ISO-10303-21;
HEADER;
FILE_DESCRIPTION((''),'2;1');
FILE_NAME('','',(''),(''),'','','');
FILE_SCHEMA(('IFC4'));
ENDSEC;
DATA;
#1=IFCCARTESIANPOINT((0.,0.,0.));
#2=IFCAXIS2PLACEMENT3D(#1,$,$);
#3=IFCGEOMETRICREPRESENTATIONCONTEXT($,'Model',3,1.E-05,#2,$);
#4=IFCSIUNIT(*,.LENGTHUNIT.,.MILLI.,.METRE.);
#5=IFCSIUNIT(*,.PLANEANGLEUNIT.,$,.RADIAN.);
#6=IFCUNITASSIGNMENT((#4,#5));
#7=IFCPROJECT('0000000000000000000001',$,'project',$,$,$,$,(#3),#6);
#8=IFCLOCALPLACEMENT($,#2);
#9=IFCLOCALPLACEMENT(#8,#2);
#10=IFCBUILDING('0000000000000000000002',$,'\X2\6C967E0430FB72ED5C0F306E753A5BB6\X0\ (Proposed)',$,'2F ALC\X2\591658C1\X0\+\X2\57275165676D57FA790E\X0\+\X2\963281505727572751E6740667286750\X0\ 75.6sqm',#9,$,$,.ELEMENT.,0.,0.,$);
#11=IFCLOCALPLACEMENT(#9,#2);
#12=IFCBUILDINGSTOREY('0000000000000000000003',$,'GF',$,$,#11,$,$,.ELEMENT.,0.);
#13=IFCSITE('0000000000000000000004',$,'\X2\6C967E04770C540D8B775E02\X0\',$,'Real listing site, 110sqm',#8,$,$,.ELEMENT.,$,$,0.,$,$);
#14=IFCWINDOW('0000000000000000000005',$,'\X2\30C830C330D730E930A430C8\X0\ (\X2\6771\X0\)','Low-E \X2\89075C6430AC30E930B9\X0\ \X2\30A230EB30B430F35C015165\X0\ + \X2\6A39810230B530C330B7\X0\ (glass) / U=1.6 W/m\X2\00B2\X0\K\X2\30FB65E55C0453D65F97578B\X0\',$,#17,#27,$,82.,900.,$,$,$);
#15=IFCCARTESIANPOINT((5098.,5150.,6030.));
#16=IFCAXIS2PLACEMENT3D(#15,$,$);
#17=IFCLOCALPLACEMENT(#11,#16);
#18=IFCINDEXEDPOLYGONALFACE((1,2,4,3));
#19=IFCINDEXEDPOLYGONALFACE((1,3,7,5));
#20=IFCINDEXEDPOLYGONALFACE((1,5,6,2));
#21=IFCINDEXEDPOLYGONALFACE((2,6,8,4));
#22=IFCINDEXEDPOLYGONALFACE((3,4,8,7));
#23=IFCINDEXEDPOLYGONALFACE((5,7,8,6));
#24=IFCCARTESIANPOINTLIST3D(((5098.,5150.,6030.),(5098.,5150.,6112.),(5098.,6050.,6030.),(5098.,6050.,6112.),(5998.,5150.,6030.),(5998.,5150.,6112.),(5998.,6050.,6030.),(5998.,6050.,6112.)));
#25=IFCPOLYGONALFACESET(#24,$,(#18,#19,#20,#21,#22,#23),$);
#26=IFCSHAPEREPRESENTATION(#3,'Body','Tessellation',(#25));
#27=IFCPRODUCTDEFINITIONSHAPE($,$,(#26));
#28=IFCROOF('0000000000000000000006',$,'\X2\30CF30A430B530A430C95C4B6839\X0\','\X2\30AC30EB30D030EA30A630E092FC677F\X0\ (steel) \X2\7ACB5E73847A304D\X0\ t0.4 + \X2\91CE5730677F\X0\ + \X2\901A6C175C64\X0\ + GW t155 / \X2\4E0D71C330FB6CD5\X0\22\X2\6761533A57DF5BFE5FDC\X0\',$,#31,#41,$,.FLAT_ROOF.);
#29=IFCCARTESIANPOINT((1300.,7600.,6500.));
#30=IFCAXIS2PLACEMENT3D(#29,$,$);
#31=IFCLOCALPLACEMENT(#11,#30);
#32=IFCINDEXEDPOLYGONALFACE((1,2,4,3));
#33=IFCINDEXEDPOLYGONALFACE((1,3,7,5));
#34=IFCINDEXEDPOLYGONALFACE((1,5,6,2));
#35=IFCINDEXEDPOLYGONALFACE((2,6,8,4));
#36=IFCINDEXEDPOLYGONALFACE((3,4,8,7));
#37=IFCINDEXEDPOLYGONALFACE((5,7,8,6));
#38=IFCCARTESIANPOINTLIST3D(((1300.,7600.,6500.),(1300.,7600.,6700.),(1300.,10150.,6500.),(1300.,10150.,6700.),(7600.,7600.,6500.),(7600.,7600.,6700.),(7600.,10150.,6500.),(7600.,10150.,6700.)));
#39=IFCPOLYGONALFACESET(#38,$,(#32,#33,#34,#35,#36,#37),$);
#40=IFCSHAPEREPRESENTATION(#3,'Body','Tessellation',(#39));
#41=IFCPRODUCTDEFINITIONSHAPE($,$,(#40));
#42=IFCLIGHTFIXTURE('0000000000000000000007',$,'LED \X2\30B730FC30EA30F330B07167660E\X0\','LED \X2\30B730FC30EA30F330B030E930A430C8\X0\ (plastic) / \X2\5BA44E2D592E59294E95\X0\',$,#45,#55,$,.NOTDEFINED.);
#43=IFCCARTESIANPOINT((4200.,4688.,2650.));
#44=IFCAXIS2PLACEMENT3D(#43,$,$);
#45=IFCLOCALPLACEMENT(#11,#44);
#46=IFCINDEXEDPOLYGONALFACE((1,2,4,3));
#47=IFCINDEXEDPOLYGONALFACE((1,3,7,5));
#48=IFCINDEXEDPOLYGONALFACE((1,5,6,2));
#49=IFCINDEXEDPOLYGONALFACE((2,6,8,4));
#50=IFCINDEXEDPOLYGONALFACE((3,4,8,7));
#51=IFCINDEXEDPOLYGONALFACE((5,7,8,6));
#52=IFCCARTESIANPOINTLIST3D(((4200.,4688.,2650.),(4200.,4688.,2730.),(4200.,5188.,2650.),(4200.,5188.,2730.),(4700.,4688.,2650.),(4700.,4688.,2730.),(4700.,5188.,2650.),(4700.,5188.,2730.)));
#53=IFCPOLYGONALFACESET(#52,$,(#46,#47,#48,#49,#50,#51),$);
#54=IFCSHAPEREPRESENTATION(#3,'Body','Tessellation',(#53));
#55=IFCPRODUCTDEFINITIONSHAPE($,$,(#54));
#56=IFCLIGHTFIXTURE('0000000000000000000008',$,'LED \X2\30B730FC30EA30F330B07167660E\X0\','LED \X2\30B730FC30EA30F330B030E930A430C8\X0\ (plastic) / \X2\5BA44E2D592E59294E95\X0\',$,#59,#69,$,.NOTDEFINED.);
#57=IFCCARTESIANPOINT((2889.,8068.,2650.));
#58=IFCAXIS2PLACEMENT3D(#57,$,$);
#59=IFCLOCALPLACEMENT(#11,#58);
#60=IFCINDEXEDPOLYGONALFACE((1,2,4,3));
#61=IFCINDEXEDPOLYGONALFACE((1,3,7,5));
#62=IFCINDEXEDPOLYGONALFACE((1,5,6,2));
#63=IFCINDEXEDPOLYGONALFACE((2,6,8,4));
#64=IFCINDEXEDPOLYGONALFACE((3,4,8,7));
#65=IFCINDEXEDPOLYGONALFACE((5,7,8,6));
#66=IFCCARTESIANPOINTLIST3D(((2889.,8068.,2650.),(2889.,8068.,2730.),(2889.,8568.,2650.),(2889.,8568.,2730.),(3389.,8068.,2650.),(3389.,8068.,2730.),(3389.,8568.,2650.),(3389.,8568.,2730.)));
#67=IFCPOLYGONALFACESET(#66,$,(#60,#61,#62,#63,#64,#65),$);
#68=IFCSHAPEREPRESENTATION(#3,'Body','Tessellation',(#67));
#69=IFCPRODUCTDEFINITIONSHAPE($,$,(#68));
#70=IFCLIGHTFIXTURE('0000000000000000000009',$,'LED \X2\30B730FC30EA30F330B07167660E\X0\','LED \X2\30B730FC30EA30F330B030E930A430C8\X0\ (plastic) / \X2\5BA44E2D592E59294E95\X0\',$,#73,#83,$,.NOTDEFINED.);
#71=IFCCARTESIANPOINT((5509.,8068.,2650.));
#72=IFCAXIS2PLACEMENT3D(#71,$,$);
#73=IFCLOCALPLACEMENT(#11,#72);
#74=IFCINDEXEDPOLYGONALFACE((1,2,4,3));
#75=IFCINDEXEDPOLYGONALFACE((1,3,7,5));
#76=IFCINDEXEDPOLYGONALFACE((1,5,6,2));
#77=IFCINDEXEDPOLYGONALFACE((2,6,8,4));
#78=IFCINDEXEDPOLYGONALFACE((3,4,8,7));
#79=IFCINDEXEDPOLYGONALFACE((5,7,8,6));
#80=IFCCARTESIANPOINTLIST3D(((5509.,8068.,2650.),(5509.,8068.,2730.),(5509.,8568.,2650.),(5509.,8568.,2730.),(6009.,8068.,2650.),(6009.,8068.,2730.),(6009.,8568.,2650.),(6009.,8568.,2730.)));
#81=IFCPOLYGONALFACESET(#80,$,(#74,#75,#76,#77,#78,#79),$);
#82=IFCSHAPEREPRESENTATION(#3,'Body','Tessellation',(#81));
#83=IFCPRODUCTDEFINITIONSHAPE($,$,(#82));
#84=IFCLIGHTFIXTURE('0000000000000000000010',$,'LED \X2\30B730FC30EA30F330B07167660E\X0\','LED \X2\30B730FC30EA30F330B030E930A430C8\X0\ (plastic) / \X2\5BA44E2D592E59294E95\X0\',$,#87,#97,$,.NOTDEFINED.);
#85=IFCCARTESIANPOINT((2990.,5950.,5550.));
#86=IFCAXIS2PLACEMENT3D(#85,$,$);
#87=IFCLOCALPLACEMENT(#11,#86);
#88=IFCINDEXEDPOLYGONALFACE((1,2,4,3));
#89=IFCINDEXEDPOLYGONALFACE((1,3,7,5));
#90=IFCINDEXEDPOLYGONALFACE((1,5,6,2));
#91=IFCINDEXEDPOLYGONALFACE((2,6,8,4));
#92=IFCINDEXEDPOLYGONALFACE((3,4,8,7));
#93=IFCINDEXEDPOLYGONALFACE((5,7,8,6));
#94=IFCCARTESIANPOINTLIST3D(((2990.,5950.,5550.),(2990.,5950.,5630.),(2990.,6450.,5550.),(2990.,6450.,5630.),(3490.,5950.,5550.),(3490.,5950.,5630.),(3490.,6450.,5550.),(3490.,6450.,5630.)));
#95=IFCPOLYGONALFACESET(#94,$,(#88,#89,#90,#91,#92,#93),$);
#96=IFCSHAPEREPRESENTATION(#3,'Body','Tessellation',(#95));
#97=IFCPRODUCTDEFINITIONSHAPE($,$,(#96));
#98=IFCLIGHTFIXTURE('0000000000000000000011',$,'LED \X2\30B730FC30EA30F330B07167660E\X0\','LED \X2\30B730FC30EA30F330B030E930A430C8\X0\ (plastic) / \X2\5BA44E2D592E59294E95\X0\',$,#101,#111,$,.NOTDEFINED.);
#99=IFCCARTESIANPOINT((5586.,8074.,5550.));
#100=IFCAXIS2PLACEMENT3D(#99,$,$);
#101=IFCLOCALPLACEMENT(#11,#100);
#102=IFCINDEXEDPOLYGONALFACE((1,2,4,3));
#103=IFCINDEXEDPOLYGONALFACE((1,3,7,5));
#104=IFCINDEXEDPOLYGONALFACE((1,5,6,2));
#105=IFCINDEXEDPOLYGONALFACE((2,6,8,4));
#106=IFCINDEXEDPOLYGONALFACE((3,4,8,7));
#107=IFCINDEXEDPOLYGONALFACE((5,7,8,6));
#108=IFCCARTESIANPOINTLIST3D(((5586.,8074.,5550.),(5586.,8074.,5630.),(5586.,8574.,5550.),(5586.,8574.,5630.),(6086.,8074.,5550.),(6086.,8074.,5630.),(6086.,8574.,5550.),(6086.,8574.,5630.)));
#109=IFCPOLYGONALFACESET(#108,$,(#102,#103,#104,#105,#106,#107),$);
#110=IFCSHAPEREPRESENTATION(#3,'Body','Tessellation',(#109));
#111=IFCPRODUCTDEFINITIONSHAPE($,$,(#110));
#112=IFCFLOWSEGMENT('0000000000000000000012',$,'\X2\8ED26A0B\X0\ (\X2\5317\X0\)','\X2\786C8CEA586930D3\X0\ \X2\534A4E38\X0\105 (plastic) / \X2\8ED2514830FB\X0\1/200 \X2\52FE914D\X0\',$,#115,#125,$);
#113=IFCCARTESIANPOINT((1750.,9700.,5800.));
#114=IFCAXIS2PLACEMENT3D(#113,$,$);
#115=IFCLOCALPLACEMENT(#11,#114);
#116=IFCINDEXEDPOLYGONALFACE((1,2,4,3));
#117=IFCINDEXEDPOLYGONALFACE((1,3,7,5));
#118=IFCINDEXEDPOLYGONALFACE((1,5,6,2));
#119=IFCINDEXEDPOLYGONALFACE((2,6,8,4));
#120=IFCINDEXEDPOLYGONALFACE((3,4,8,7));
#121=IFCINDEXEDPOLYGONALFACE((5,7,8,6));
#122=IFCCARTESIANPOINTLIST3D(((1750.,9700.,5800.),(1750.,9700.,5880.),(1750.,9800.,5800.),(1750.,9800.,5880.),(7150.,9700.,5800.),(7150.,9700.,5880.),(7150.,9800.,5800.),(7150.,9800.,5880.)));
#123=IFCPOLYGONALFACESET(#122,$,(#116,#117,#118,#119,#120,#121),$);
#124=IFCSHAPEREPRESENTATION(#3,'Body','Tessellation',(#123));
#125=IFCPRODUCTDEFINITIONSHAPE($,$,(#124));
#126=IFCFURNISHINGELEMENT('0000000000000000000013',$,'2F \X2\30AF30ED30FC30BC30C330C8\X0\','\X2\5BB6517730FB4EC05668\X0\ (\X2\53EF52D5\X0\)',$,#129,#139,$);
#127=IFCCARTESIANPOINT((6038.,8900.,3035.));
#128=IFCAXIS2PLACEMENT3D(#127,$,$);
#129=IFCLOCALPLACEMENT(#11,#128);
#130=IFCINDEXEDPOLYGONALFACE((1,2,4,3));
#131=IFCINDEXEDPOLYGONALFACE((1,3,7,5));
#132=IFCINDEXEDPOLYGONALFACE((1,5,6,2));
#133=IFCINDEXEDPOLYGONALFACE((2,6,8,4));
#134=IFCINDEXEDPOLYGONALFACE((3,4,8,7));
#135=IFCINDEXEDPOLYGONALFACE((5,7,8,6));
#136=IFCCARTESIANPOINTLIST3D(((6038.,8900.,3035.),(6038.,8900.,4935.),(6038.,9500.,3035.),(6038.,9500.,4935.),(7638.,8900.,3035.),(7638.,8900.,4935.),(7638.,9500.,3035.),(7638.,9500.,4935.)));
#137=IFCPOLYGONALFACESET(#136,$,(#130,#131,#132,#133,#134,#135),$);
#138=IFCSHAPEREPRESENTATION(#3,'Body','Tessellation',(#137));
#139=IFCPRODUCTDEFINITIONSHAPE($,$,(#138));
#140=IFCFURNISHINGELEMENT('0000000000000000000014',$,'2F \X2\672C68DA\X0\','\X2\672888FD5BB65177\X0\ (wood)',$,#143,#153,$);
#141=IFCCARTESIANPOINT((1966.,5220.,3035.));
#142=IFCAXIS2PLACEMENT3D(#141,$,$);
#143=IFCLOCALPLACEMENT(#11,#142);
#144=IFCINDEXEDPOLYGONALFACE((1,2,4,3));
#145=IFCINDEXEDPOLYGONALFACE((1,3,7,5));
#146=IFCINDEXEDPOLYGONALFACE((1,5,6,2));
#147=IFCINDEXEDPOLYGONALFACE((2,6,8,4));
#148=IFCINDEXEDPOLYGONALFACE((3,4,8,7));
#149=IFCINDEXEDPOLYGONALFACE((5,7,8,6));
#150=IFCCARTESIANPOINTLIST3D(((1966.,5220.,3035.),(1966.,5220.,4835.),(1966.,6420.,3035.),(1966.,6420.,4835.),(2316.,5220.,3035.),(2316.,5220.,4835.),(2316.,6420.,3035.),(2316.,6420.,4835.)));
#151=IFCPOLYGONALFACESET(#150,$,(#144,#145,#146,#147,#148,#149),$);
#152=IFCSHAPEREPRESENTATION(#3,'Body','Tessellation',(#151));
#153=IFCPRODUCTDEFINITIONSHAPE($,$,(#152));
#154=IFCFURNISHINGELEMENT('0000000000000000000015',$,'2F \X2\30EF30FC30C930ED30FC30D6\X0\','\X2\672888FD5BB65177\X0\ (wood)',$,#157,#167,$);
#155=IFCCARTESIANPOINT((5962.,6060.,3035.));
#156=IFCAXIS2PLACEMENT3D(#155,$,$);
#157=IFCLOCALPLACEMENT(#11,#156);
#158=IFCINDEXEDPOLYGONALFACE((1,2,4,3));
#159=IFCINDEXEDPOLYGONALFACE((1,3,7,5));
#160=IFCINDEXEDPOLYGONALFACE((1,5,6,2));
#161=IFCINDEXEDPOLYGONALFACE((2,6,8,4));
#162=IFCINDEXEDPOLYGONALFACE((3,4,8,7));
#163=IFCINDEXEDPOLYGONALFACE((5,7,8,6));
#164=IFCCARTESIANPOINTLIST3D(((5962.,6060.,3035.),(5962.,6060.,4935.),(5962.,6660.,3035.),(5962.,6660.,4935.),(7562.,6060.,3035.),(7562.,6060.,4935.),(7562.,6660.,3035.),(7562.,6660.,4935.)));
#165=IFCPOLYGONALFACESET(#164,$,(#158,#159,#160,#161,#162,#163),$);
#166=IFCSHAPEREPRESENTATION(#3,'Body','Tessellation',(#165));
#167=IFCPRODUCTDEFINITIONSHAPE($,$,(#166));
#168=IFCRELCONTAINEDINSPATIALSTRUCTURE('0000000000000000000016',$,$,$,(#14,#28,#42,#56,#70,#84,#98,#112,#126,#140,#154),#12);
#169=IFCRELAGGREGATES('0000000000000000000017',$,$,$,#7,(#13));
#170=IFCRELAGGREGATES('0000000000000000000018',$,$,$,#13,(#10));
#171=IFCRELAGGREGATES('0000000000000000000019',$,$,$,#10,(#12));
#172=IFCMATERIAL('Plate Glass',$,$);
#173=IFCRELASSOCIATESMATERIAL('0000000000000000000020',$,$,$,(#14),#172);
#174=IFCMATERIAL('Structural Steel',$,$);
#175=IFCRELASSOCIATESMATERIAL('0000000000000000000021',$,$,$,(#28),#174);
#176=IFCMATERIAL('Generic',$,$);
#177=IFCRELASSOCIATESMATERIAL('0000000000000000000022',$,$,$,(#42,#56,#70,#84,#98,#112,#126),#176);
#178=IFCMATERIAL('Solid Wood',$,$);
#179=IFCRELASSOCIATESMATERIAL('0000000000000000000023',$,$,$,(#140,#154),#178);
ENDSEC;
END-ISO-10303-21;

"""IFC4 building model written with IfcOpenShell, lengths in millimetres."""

from ifc_helpers import new_model, si_unit, frame, frame_2d, origin, place, context, project, spatial, rectangle, extrude, material, element, save


model = new_model("IFC4")

# Units and contexts
model_context = context("Model", 3, precision=1e-05, world=origin())
ifc_project = project(units=[si_unit("LENGTHUNIT", "METRE", prefix="MILLI"), si_unit("PLANEANGLEUNIT", "RADIAN")], contexts=[model_context])

# Site, building, storey
site_placement = place(None, origin())
site = spatial("IfcSite", under=ifc_project, at=site_placement, Name="沖縄県名護市", ObjectType="Real listing site, 110sqm", CompositionType="ELEMENT", RefElevation=0.0)
building_placement = place(site_placement, origin())
building = spatial("IfcBuilding", under=site, at=building_placement, Name="沖縄・狭小の町家 (Proposed)", ObjectType="2F ALC外壁+圧入杭基礎+防腐圧圧処理木材 75.6sqm", CompositionType="ELEMENT", ElevationOfRefHeight=0.0, ElevationOfTerrain=0.0)
storey_placement = place(building_placement, origin())
storey = spatial("IfcBuildingStorey", under=building, at=storey_placement, Name="GF", CompositionType="ELEMENT", Elevation=0.0)

# Shared definitions
ifc_material_1 = material(Name="Solid Wood")

# Shared definitions
ifc_material_2 = material(Name="Plate Glass")

# Window
window_1_placement = place(storey_placement, frame((5098.0, 5150.0, 6030.0)))
element("IfcWindow", 1, at=window_1_placement, inside=storey, material=ifc_material_2, Name="トップライト (東)", Description="Low-E 複層ガラス アルゴン封入 + 樹脂サッシ (glass) / U=1.6 W/m²K・日射取得型", OverallHeight=82.0, OverallWidth=900.0, context=model_context, shape_type="SweptSolid", body=[
    extrude(rectangle(XDim=900.0, YDim=900.0, at=frame_2d((450.0, 450.0))), frame((5098.0, 5150.0, 6030.0)), (0.0, 0.0, 1.0), 82.0),
])

# Roof
ifc_material_3 = material(Name="Structural Steel")
roof_placement = place(storey_placement, frame((1300.0, 7600.0, 6500.0)))
element("IfcRoof", 2, at=roof_placement, inside=storey, material=ifc_material_3, Name="ハイサイド屋根", Description="ガルバリウム鋼板 (steel) 立平葺き t0.4 + 野地板 + 通気層 + GW t155 / 不燃・法22条区域対応", PredefinedType="FLAT_ROOF", context=model_context, shape_type="SweptSolid", body=[
    extrude(rectangle(XDim=6300.0, YDim=2550.0, at=frame_2d((3150.0, 1275.0))), frame((1300.0, 7600.0, 6500.0)), (0.0, 0.0, 1.0), 200.0),
])

# Light fixtures
ifc_material_4 = material(Name="Generic")
light_fixture_1_placement = place(storey_placement, frame((4200.0, 4688.0, 2650.0)))
element("IfcLightFixture", 3, at=light_fixture_1_placement, inside=storey, material=ifc_material_4, Name="LED シーリング照明", Description="LED シーリングライト (plastic) / 室中央天井", PredefinedType="NOTDEFINED", context=model_context, shape_type="SweptSolid", body=[
    extrude(rectangle(XDim=500.0, YDim=500.0, at=frame_2d((250.0, 250.0))), frame((4200.0, 4688.0, 2650.0)), (0.0, 0.0, 1.0), 80.0),
])
light_fixture_2_placement = place(storey_placement, frame((2889.0, 8068.0, 2650.0)))
element("IfcLightFixture", 4, at=light_fixture_2_placement, inside=storey, material=ifc_material_4, Name="LED シーリング照明", Description="LED シーリングライト (plastic) / 室中央天井", PredefinedType="NOTDEFINED", context=model_context, shape_type="SweptSolid", body=[
    extrude(rectangle(XDim=500.0, YDim=500.0, at=frame_2d((250.0, 250.0))), frame((2889.0, 8068.0, 2650.0)), (0.0, 0.0, 1.0), 80.0),
])
light_fixture_3_placement = place(storey_placement, frame((5509.0, 8068.0, 2650.0)))
element("IfcLightFixture", 5, at=light_fixture_3_placement, inside=storey, material=ifc_material_4, Name="LED シーリング照明", Description="LED シーリングライト (plastic) / 室中央天井", PredefinedType="NOTDEFINED", context=model_context, shape_type="SweptSolid", body=[
    extrude(rectangle(XDim=500.0, YDim=500.0, at=frame_2d((250.0, 250.0))), frame((5509.0, 8068.0, 2650.0)), (0.0, 0.0, 1.0), 80.0),
])
light_fixture_4_placement = place(storey_placement, frame((2990.0, 5950.0, 5550.0)))
element("IfcLightFixture", 6, at=light_fixture_4_placement, inside=storey, material=ifc_material_4, Name="LED シーリング照明", Description="LED シーリングライト (plastic) / 室中央天井", PredefinedType="NOTDEFINED", context=model_context, shape_type="SweptSolid", body=[
    extrude(rectangle(XDim=500.0, YDim=500.0, at=frame_2d((250.0, 250.0))), frame((2990.0, 5950.0, 5550.0)), (0.0, 0.0, 1.0), 80.0),
])
light_fixture_5_placement = place(storey_placement, frame((5586.0, 8074.0, 5550.0)))
element("IfcLightFixture", 7, at=light_fixture_5_placement, inside=storey, material=ifc_material_4, Name="LED シーリング照明", Description="LED シーリングライト (plastic) / 室中央天井", PredefinedType="NOTDEFINED", context=model_context, shape_type="SweptSolid", body=[
    extrude(rectangle(XDim=500.0, YDim=500.0, at=frame_2d((250.0, 250.0))), frame((5586.0, 8074.0, 5550.0)), (0.0, 0.0, 1.0), 80.0),
])

# Flow segment
flow_segment_placement = place(storey_placement, frame((1750.0, 9700.0, 5800.0)))
element("IfcFlowSegment", 8, at=flow_segment_placement, inside=storey, material=ifc_material_4, Name="軒樋 (北)", Description="硬質塩ビ 半丸105 (plastic) / 軒先・1/200 勾配", context=model_context, shape_type="SweptSolid", body=[
    extrude(rectangle(XDim=5400.0, YDim=100.0, at=frame_2d((2700.0, 50.0))), frame((1750.0, 9700.0, 5800.0)), (0.0, 0.0, 1.0), 80.0),
])

# Furnishing elements
furnishing_1_placement = place(storey_placement, frame((6038.0, 8900.0, 3035.0)))
element("IfcFurnishingElement", 9, at=furnishing_1_placement, inside=storey, material=ifc_material_4, Name="2F クローゼット", Description="家具・什器 (可動)", context=model_context, shape_type="SweptSolid", body=[
    extrude(rectangle(XDim=1600.0, YDim=600.0, at=frame_2d((800.0, 300.0))), frame((6038.0, 8900.0, 3035.0)), (0.0, 0.0, 1.0), 1900.0),
])
furnishing_2_placement = place(storey_placement, frame((1966.0, 5220.0, 3035.0)))
element("IfcFurnishingElement", 10, at=furnishing_2_placement, inside=storey, material=ifc_material_1, Name="2F 本棚", Description="木製家具 (wood)", context=model_context, shape_type="SweptSolid", body=[
    extrude(rectangle(XDim=350.0, YDim=1200.0, at=frame_2d((175.0, 600.0))), frame((1966.0, 5220.0, 3035.0)), (0.0, 0.0, 1.0), 1800.0),
])
furnishing_3_placement = place(storey_placement, frame((5962.0, 6060.0, 3035.0)))
element("IfcFurnishingElement", 11, at=furnishing_3_placement, inside=storey, material=ifc_material_1, Name="2F ワードローブ", Description="木製家具 (wood)", context=model_context, shape_type="SweptSolid", body=[
    extrude(rectangle(XDim=1600.0, YDim=600.0, at=frame_2d((800.0, 300.0))), frame((5962.0, 6060.0, 3035.0)), (0.0, 0.0, 1.0), 1900.0),
])

save(model, "model.ifc")
